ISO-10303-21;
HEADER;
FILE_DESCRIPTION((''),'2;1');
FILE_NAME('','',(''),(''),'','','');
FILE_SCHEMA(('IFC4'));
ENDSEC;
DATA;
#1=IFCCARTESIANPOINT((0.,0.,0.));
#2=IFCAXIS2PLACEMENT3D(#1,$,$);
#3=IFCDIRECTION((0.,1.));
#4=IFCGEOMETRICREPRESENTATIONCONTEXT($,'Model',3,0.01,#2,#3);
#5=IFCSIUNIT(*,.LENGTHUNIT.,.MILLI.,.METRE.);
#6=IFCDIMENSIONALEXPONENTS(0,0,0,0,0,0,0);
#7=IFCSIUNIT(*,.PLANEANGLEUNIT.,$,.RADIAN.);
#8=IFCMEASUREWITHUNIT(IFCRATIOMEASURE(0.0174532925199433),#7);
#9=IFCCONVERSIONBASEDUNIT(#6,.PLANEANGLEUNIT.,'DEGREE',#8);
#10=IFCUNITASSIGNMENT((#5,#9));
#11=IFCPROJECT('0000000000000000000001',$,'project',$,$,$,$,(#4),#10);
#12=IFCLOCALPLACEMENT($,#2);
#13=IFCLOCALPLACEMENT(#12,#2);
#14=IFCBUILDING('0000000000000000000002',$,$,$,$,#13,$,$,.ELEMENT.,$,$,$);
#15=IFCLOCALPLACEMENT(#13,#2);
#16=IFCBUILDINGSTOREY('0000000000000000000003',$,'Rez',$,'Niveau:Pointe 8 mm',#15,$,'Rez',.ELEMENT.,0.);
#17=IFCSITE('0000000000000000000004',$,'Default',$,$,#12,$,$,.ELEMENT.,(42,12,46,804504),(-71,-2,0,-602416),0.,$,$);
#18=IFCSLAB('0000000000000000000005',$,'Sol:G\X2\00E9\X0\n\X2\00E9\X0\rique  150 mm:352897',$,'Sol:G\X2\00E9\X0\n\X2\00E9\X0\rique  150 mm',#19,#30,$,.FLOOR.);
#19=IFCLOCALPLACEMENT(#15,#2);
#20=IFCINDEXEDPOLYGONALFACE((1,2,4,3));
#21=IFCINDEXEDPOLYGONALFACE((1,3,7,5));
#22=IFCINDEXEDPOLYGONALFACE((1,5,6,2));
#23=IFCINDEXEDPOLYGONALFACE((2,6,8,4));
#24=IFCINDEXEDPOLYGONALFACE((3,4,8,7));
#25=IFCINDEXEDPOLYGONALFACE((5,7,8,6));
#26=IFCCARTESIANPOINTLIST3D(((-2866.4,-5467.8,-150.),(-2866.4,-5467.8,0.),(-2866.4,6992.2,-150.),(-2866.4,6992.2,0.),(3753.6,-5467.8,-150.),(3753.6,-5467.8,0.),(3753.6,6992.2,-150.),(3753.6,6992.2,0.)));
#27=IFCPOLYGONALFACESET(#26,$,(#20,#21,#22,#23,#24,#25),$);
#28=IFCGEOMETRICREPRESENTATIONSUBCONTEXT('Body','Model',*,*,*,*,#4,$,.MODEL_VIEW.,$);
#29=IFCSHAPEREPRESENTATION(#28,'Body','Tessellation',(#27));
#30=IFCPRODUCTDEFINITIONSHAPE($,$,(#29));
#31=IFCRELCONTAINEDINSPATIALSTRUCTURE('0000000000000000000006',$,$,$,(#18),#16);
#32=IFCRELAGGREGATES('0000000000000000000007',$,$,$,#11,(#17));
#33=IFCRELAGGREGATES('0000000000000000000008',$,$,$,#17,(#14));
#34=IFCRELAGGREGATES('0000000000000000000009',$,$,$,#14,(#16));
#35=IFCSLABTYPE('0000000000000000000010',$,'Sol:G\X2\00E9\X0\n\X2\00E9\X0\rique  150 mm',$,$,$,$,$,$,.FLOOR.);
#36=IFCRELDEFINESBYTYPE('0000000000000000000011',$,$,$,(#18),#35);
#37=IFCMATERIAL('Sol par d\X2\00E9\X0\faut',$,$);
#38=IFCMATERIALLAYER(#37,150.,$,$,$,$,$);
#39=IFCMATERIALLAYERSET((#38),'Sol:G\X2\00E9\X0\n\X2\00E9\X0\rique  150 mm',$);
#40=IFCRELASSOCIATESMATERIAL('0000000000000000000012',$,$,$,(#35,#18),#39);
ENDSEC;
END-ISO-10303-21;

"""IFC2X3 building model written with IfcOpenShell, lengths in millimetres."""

from ifc_helpers import new_model, entity, si_unit, converted_unit, direction, frame, frame_2d, origin, place, context, subcontext, project, spatial, rectangle, extrude, material, layer, layer_set, layer_usage, type_object, element, save


model = new_model("IFC2X3")

# Units and contexts
model_context = context("Model", 3, precision=0.01, world=origin(), true_north=direction((0.0, 1.0)))
body_context = subcontext(model_context, "Body", "Model", "MODEL_VIEW")
ifc_project = project(units=[si_unit("LENGTHUNIT", "METRE", prefix="MILLI"), converted_unit("PLANEANGLEUNIT", "DEGREE", entity("IfcRatioMeasure", 0.0174532925199433), si_unit("PLANEANGLEUNIT", "RADIAN"), dimensions=[0, 0, 0, 0, 0, 0, 0])], contexts=[model_context])

# Site, building, storey
site_placement = place(None, origin())
site = spatial("IfcSite", under=ifc_project, at=site_placement, Name="Default", CompositionType="ELEMENT", RefLatitude=(42, 12, 46, 804504), RefLongitude=(-71, -2, 0, -602416), RefElevation=0.0)
building_placement = place(site_placement, origin())
building = spatial("IfcBuilding", under=site, at=building_placement, CompositionType="ELEMENT")
storey_placement = place(building_placement, origin())
storey = spatial("IfcBuildingStorey", under=building, at=storey_placement, Name="Rez", ObjectType="Niveau:Pointe 8 mm", LongName="Rez", CompositionType="ELEMENT", Elevation=0.0)

# Slab
ifc_material = material(Name="Sol par défaut")
ifc_layer = layer(ifc_material, 150.0)
ifc_layer_set = layer_set([ifc_layer], Name="Sol:Générique  150 mm")
ifc_layer_usage = layer_usage(ifc_layer_set, "AXIS3", "POSITIVE", 0.0)
slab_type = type_object("IfcSlabType", Name="Sol:Générique  150 mm", PredefinedType="FLOOR", material=ifc_layer_set)
slab_placement = place(storey_placement, origin())
element("IfcSlab", 1, at=slab_placement, inside=storey, type_object=slab_type, material=ifc_layer_usage, Name="Sol:Générique  150 mm:352897", ObjectType="Sol:Générique  150 mm", PredefinedType="FLOOR", context=body_context, shape_type="SweptSolid", body=[
    extrude(rectangle(XDim=12460.0, YDim=6620.0, at=frame_2d((0.0, 0.0), x_axis=(1.0, 0.0))), frame((443.6, 762.2, 0.0), z_axis=(0.0, 0.0, -1.0), x_axis=(0.0, 1.0, 0.0)), (0.0, 0.0, 1.0), 150.0),
])

save(model, "model.ifc")
